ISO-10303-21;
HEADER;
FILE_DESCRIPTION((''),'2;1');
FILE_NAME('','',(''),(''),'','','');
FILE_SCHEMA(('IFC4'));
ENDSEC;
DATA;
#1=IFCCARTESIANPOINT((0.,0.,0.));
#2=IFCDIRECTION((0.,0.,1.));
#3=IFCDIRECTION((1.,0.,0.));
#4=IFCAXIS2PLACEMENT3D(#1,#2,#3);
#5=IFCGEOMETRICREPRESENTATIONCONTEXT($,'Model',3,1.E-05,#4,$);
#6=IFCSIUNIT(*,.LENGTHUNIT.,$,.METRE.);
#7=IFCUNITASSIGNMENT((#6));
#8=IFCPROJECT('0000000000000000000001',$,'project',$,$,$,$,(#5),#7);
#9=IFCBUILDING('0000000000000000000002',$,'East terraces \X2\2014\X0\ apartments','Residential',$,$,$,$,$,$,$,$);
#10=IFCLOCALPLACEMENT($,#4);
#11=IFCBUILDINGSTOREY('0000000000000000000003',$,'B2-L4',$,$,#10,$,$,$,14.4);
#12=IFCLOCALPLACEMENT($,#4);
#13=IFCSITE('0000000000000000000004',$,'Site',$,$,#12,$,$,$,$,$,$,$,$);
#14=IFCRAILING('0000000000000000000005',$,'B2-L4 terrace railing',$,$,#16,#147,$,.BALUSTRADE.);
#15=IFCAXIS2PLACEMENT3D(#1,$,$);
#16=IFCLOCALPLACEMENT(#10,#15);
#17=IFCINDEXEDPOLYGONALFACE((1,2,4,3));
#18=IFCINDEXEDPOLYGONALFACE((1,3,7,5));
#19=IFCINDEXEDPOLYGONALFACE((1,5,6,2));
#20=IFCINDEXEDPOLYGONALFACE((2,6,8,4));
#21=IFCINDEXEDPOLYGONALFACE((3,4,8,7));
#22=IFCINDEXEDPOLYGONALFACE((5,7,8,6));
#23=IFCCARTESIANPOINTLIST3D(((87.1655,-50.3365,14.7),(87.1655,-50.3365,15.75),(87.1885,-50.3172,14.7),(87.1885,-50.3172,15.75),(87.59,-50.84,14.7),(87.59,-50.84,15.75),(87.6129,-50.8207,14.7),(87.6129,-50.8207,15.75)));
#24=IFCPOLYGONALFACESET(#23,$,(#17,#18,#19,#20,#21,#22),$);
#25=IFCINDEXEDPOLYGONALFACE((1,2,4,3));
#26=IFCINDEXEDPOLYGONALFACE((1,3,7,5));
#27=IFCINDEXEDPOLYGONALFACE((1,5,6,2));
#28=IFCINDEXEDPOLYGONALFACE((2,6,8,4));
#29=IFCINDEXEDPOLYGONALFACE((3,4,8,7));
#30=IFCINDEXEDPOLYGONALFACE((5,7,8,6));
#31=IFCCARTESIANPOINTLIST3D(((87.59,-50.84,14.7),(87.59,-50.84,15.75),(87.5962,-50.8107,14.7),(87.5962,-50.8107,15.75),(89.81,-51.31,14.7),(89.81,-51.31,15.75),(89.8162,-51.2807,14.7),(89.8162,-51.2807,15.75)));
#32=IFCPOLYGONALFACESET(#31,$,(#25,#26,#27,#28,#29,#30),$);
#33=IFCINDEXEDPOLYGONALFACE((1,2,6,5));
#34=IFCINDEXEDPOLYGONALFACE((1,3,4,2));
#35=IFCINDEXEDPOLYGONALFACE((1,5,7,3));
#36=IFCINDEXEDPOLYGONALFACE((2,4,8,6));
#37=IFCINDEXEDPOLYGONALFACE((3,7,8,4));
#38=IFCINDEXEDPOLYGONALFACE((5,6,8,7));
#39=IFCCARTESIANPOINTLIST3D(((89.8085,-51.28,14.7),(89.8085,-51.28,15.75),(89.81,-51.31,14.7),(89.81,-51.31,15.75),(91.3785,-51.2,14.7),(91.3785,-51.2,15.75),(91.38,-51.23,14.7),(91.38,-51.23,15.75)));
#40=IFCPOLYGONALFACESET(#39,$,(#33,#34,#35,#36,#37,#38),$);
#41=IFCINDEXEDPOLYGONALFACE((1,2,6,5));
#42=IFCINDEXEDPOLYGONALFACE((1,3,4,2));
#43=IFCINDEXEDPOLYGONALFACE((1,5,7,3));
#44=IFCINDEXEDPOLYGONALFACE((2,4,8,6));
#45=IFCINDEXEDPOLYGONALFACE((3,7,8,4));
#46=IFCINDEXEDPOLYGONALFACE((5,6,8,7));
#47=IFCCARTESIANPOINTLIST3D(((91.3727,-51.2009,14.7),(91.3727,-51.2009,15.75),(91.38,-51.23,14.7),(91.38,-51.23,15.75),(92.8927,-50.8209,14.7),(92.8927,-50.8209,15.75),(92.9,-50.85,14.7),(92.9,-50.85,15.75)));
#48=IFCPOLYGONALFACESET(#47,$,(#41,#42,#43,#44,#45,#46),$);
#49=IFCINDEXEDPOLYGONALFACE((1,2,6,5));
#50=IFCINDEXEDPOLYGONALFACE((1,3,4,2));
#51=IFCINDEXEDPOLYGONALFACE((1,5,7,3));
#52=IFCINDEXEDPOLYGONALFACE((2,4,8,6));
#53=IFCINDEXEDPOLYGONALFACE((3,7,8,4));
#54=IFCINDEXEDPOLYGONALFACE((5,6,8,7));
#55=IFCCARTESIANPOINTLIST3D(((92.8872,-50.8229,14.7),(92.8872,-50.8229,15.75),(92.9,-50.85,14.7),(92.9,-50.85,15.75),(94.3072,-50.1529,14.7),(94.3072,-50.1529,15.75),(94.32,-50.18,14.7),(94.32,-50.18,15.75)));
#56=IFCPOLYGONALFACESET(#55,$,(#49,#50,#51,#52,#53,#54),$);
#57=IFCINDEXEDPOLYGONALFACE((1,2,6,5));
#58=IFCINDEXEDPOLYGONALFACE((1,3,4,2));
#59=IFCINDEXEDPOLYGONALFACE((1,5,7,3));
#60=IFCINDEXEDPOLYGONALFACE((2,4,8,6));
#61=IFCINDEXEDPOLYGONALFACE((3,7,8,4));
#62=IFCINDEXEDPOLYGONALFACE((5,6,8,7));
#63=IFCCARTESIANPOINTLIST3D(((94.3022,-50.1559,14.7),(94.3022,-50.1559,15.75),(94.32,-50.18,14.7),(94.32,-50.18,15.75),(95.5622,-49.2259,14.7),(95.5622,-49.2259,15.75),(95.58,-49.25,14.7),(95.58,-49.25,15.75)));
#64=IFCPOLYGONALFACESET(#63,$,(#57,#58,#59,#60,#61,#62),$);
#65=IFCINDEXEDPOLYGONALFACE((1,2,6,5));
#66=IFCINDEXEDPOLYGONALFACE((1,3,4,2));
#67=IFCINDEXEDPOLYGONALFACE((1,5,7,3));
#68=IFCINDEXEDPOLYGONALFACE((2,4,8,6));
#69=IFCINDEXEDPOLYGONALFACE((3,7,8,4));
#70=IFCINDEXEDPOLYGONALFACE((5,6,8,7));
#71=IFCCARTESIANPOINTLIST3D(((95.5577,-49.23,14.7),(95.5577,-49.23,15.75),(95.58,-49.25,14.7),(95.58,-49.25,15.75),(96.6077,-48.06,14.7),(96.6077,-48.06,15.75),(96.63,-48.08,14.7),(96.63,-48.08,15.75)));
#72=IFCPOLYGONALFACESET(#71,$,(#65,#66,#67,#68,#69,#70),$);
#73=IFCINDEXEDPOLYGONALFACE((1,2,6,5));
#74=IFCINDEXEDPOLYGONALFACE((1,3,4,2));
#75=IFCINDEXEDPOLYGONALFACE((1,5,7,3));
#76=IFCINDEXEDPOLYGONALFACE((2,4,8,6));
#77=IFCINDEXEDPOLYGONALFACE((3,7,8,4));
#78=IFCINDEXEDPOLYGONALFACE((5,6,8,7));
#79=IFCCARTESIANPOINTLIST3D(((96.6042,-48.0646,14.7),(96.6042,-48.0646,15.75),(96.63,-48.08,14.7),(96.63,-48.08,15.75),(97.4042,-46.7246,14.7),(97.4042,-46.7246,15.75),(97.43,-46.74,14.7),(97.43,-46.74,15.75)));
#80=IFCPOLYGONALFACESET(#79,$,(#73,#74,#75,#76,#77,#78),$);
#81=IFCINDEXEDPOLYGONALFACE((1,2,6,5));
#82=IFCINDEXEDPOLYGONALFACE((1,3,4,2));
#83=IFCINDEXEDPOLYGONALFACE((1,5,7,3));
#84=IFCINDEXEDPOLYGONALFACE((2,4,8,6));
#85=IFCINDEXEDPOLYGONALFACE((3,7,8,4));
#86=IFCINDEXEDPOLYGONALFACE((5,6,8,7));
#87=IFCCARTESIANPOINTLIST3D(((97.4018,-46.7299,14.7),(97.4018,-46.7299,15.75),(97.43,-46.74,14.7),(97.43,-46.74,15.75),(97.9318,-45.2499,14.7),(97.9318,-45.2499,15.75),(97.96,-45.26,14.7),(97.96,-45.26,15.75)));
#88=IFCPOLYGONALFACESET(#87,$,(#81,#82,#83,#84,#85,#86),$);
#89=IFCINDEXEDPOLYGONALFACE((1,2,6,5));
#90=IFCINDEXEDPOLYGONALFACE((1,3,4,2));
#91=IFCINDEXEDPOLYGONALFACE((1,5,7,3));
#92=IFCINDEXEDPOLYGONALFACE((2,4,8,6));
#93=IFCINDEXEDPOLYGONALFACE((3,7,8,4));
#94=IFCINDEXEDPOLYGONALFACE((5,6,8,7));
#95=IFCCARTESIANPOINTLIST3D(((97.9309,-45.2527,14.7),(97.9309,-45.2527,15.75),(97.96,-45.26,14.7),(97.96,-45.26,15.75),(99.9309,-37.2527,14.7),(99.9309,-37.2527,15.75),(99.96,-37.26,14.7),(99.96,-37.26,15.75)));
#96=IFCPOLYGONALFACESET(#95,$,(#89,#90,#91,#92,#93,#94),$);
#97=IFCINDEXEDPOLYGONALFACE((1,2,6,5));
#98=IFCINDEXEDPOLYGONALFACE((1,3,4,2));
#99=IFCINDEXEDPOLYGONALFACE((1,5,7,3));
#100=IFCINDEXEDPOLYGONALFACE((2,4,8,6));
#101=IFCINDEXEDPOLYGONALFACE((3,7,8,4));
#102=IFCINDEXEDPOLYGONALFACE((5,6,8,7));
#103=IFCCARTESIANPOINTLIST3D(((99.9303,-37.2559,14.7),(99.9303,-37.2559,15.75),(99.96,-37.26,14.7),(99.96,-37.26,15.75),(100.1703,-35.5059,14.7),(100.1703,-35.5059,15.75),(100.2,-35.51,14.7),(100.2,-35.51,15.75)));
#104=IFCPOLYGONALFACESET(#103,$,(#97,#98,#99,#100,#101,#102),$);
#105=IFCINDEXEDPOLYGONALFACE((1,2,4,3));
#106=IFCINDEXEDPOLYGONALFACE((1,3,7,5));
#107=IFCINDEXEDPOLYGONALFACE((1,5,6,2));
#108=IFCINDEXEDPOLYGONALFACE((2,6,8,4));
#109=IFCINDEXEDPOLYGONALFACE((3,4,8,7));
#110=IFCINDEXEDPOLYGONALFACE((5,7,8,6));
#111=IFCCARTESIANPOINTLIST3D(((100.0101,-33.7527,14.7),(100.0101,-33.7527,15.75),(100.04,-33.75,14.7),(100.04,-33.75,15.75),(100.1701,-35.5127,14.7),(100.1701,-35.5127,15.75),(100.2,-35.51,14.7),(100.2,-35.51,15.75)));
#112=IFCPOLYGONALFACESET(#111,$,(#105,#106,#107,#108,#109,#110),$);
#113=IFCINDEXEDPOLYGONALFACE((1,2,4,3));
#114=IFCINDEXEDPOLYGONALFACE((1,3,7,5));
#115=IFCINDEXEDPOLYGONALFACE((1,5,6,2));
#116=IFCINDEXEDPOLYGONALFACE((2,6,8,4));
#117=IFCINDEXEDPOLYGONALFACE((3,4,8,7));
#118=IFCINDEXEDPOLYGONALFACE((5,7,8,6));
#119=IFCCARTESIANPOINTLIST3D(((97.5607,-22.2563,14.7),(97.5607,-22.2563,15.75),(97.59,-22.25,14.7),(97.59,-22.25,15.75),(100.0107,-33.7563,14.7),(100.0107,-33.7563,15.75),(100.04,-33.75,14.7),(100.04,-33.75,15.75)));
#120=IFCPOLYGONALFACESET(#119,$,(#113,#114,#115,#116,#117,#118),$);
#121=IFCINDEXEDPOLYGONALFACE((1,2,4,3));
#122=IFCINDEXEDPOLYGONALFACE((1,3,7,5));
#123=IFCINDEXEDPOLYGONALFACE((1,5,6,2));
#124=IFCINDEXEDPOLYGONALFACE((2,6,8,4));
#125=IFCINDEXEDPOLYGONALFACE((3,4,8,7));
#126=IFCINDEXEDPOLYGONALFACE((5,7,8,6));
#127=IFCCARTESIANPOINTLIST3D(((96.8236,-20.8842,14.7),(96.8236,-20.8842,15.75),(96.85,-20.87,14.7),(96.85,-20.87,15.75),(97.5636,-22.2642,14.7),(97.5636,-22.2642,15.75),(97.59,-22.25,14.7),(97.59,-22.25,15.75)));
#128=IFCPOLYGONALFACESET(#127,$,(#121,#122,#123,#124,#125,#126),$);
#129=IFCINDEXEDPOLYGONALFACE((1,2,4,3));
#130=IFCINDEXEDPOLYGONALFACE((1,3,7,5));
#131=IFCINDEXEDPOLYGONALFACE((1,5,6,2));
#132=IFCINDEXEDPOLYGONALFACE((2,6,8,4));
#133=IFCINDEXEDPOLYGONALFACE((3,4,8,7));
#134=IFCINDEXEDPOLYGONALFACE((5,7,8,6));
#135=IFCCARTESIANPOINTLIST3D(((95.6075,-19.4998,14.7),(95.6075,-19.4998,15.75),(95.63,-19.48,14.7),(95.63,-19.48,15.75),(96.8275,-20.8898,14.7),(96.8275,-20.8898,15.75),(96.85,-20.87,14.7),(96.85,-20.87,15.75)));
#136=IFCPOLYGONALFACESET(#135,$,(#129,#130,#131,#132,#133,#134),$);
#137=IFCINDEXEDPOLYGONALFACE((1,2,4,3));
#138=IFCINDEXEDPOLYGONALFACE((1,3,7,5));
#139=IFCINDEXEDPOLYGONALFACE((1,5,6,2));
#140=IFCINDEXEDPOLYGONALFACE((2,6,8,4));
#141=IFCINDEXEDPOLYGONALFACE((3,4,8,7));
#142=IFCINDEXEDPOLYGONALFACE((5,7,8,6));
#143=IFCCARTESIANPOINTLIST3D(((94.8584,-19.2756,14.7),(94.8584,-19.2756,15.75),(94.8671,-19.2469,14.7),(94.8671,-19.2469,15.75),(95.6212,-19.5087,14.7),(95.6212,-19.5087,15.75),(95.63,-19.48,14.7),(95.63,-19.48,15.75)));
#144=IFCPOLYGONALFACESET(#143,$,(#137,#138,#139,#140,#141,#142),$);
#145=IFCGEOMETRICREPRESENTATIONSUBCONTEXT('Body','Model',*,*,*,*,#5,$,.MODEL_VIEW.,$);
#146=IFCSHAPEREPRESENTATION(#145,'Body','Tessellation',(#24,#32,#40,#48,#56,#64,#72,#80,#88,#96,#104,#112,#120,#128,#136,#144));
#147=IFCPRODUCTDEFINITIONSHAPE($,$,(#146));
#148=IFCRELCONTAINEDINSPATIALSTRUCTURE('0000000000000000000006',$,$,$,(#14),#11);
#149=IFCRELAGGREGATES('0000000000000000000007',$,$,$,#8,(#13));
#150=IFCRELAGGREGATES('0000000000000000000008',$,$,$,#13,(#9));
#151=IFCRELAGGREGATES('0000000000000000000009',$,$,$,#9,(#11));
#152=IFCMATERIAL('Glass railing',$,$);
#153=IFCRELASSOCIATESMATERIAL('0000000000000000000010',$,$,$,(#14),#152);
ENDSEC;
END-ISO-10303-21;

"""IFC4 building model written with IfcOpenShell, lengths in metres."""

from ifc_helpers import new_model, si_unit, frame, origin_with_axes, place, context, subcontext, project, spatial, polyline, outline, extrude, material, element, save


model = new_model("IFC4")

# Units and contexts
model_context = context("Model", 3, precision=1e-05, world=origin_with_axes())
body_context = subcontext(model_context, "Body", "Model", "MODEL_VIEW")
ifc_project = project(units=[si_unit("LENGTHUNIT", "METRE")], contexts=[model_context])

# Site, building, storey
site_placement = place(None, origin_with_axes())
site = spatial("IfcSite", under=ifc_project, at=site_placement, Name="Site")
building = spatial("IfcBuilding", under=site, Name="East terraces — apartments", Description="Residential")
storey_placement = place(None, origin_with_axes())
storey = spatial("IfcBuildingStorey", under=building, at=storey_placement, Name="B2-L4", Elevation=14.4)

# Railing
ifc_material_1 = material(Name="Glass railing")
railing_placement = place(storey_placement, origin_with_axes())
element("IfcRailing", 1, at=railing_placement, inside=storey, material=ifc_material_1, Name="B2-L4 terrace railing", PredefinedType="BALUSTRADE", context=body_context, shape_type="SweptSolid", body=[
    extrude(outline(polyline([(87.1655, -50.3365), (87.59, -50.84), (87.6129, -50.8207), (87.1885, -50.3172), (87.1655, -50.3365)])), frame((0.0, 0.0, 14.7), z_axis=(0.0, 0.0, 1.0), x_axis=(1.0, 0.0, 0.0)), (0.0, 0.0, 1.0), 1.05),
    extrude(outline(polyline([(87.59, -50.84), (89.81, -51.31), (89.8162, -51.2807), (87.5962, -50.8107), (87.59, -50.84)])), frame((0.0, 0.0, 14.7), z_axis=(0.0, 0.0, 1.0), x_axis=(1.0, 0.0, 0.0)), (0.0, 0.0, 1.0), 1.05),
    extrude(outline(polyline([(89.81, -51.31), (91.38, -51.23), (91.3785, -51.2), (89.8085, -51.28), (89.81, -51.31)])), frame((0.0, 0.0, 14.7), z_axis=(0.0, 0.0, 1.0), x_axis=(1.0, 0.0, 0.0)), (0.0, 0.0, 1.0), 1.05),
    extrude(outline(polyline([(91.38, -51.23), (92.9, -50.85), (92.8927, -50.8209), (91.3727, -51.2009), (91.38, -51.23)])), frame((0.0, 0.0, 14.7), z_axis=(0.0, 0.0, 1.0), x_axis=(1.0, 0.0, 0.0)), (0.0, 0.0, 1.0), 1.05),
    extrude(outline(polyline([(92.9, -50.85), (94.32, -50.18), (94.3072, -50.1529), (92.8872, -50.8229), (92.9, -50.85)])), frame((0.0, 0.0, 14.7), z_axis=(0.0, 0.0, 1.0), x_axis=(1.0, 0.0, 0.0)), (0.0, 0.0, 1.0), 1.05),
    extrude(outline(polyline([(94.32, -50.18), (95.58, -49.25), (95.5622, -49.2259), (94.3022, -50.1559), (94.32, -50.18)])), frame((0.0, 0.0, 14.7), z_axis=(0.0, 0.0, 1.0), x_axis=(1.0, 0.0, 0.0)), (0.0, 0.0, 1.0), 1.05),
    extrude(outline(polyline([(95.58, -49.25), (96.63, -48.08), (96.6077, -48.06), (95.5577, -49.23), (95.58, -49.25)])), frame((0.0, 0.0, 14.7), z_axis=(0.0, 0.0, 1.0), x_axis=(1.0, 0.0, 0.0)), (0.0, 0.0, 1.0), 1.05),
    extrude(outline(polyline([(96.63, -48.08), (97.43, -46.74), (97.4042, -46.7246), (96.6042, -48.0646), (96.63, -48.08)])), frame((0.0, 0.0, 14.7), z_axis=(0.0, 0.0, 1.0), x_axis=(1.0, 0.0, 0.0)), (0.0, 0.0, 1.0), 1.05),
    extrude(outline(polyline([(97.43, -46.74), (97.96, -45.26), (97.9318, -45.2499), (97.4018, -46.7299), (97.43, -46.74)])), frame((0.0, 0.0, 14.7), z_axis=(0.0, 0.0, 1.0), x_axis=(1.0, 0.0, 0.0)), (0.0, 0.0, 1.0), 1.05),
    extrude(outline(polyline([(97.96, -45.26), (99.96, -37.26), (99.9309, -37.2527), (97.9309, -45.2527), (97.96, -45.26)])), frame((0.0, 0.0, 14.7), z_axis=(0.0, 0.0, 1.0), x_axis=(1.0, 0.0, 0.0)), (0.0, 0.0, 1.0), 1.05),
    extrude(outline(polyline([(99.96, -37.26), (100.2, -35.51), (100.1703, -35.5059), (99.9303, -37.2559), (99.96, -37.26)])), frame((0.0, 0.0, 14.7), z_axis=(0.0, 0.0, 1.0), x_axis=(1.0, 0.0, 0.0)), (0.0, 0.0, 1.0), 1.05),
    extrude(outline(polyline([(100.2, -35.51), (100.04, -33.75), (100.0101, -33.7527), (100.1701, -35.5127), (100.2, -35.51)])), frame((0.0, 0.0, 14.7), z_axis=(0.0, 0.0, 1.0), x_axis=(1.0, 0.0, 0.0)), (0.0, 0.0, 1.0), 1.05),
    extrude(outline(polyline([(100.04, -33.75), (97.59, -22.25), (97.5607, -22.2563), (100.0107, -33.7563), (100.04, -33.75)])), frame((0.0, 0.0, 14.7), z_axis=(0.0, 0.0, 1.0), x_axis=(1.0, 0.0, 0.0)), (0.0, 0.0, 1.0), 1.05),
    extrude(outline(polyline([(97.59, -22.25), (96.85, -20.87), (96.8236, -20.8842), (97.5636, -22.2642), (97.59, -22.25)])), frame((0.0, 0.0, 14.7), z_axis=(0.0, 0.0, 1.0), x_axis=(1.0, 0.0, 0.0)), (0.0, 0.0, 1.0), 1.05),
    extrude(outline(polyline([(96.85, -20.87), (95.63, -19.48), (95.6075, -19.4998), (96.8275, -20.8898), (96.85, -20.87)])), frame((0.0, 0.0, 14.7), z_axis=(0.0, 0.0, 1.0), x_axis=(1.0, 0.0, 0.0)), (0.0, 0.0, 1.0), 1.05),
    extrude(outline(polyline([(95.63, -19.48), (94.8671, -19.2469), (94.8584, -19.2756), (95.6212, -19.5087), (95.63, -19.48)])), frame((0.0, 0.0, 14.7), z_axis=(0.0, 0.0, 1.0), x_axis=(1.0, 0.0, 0.0)), (0.0, 0.0, 1.0), 1.05),
])

save(model, "model.ifc")
